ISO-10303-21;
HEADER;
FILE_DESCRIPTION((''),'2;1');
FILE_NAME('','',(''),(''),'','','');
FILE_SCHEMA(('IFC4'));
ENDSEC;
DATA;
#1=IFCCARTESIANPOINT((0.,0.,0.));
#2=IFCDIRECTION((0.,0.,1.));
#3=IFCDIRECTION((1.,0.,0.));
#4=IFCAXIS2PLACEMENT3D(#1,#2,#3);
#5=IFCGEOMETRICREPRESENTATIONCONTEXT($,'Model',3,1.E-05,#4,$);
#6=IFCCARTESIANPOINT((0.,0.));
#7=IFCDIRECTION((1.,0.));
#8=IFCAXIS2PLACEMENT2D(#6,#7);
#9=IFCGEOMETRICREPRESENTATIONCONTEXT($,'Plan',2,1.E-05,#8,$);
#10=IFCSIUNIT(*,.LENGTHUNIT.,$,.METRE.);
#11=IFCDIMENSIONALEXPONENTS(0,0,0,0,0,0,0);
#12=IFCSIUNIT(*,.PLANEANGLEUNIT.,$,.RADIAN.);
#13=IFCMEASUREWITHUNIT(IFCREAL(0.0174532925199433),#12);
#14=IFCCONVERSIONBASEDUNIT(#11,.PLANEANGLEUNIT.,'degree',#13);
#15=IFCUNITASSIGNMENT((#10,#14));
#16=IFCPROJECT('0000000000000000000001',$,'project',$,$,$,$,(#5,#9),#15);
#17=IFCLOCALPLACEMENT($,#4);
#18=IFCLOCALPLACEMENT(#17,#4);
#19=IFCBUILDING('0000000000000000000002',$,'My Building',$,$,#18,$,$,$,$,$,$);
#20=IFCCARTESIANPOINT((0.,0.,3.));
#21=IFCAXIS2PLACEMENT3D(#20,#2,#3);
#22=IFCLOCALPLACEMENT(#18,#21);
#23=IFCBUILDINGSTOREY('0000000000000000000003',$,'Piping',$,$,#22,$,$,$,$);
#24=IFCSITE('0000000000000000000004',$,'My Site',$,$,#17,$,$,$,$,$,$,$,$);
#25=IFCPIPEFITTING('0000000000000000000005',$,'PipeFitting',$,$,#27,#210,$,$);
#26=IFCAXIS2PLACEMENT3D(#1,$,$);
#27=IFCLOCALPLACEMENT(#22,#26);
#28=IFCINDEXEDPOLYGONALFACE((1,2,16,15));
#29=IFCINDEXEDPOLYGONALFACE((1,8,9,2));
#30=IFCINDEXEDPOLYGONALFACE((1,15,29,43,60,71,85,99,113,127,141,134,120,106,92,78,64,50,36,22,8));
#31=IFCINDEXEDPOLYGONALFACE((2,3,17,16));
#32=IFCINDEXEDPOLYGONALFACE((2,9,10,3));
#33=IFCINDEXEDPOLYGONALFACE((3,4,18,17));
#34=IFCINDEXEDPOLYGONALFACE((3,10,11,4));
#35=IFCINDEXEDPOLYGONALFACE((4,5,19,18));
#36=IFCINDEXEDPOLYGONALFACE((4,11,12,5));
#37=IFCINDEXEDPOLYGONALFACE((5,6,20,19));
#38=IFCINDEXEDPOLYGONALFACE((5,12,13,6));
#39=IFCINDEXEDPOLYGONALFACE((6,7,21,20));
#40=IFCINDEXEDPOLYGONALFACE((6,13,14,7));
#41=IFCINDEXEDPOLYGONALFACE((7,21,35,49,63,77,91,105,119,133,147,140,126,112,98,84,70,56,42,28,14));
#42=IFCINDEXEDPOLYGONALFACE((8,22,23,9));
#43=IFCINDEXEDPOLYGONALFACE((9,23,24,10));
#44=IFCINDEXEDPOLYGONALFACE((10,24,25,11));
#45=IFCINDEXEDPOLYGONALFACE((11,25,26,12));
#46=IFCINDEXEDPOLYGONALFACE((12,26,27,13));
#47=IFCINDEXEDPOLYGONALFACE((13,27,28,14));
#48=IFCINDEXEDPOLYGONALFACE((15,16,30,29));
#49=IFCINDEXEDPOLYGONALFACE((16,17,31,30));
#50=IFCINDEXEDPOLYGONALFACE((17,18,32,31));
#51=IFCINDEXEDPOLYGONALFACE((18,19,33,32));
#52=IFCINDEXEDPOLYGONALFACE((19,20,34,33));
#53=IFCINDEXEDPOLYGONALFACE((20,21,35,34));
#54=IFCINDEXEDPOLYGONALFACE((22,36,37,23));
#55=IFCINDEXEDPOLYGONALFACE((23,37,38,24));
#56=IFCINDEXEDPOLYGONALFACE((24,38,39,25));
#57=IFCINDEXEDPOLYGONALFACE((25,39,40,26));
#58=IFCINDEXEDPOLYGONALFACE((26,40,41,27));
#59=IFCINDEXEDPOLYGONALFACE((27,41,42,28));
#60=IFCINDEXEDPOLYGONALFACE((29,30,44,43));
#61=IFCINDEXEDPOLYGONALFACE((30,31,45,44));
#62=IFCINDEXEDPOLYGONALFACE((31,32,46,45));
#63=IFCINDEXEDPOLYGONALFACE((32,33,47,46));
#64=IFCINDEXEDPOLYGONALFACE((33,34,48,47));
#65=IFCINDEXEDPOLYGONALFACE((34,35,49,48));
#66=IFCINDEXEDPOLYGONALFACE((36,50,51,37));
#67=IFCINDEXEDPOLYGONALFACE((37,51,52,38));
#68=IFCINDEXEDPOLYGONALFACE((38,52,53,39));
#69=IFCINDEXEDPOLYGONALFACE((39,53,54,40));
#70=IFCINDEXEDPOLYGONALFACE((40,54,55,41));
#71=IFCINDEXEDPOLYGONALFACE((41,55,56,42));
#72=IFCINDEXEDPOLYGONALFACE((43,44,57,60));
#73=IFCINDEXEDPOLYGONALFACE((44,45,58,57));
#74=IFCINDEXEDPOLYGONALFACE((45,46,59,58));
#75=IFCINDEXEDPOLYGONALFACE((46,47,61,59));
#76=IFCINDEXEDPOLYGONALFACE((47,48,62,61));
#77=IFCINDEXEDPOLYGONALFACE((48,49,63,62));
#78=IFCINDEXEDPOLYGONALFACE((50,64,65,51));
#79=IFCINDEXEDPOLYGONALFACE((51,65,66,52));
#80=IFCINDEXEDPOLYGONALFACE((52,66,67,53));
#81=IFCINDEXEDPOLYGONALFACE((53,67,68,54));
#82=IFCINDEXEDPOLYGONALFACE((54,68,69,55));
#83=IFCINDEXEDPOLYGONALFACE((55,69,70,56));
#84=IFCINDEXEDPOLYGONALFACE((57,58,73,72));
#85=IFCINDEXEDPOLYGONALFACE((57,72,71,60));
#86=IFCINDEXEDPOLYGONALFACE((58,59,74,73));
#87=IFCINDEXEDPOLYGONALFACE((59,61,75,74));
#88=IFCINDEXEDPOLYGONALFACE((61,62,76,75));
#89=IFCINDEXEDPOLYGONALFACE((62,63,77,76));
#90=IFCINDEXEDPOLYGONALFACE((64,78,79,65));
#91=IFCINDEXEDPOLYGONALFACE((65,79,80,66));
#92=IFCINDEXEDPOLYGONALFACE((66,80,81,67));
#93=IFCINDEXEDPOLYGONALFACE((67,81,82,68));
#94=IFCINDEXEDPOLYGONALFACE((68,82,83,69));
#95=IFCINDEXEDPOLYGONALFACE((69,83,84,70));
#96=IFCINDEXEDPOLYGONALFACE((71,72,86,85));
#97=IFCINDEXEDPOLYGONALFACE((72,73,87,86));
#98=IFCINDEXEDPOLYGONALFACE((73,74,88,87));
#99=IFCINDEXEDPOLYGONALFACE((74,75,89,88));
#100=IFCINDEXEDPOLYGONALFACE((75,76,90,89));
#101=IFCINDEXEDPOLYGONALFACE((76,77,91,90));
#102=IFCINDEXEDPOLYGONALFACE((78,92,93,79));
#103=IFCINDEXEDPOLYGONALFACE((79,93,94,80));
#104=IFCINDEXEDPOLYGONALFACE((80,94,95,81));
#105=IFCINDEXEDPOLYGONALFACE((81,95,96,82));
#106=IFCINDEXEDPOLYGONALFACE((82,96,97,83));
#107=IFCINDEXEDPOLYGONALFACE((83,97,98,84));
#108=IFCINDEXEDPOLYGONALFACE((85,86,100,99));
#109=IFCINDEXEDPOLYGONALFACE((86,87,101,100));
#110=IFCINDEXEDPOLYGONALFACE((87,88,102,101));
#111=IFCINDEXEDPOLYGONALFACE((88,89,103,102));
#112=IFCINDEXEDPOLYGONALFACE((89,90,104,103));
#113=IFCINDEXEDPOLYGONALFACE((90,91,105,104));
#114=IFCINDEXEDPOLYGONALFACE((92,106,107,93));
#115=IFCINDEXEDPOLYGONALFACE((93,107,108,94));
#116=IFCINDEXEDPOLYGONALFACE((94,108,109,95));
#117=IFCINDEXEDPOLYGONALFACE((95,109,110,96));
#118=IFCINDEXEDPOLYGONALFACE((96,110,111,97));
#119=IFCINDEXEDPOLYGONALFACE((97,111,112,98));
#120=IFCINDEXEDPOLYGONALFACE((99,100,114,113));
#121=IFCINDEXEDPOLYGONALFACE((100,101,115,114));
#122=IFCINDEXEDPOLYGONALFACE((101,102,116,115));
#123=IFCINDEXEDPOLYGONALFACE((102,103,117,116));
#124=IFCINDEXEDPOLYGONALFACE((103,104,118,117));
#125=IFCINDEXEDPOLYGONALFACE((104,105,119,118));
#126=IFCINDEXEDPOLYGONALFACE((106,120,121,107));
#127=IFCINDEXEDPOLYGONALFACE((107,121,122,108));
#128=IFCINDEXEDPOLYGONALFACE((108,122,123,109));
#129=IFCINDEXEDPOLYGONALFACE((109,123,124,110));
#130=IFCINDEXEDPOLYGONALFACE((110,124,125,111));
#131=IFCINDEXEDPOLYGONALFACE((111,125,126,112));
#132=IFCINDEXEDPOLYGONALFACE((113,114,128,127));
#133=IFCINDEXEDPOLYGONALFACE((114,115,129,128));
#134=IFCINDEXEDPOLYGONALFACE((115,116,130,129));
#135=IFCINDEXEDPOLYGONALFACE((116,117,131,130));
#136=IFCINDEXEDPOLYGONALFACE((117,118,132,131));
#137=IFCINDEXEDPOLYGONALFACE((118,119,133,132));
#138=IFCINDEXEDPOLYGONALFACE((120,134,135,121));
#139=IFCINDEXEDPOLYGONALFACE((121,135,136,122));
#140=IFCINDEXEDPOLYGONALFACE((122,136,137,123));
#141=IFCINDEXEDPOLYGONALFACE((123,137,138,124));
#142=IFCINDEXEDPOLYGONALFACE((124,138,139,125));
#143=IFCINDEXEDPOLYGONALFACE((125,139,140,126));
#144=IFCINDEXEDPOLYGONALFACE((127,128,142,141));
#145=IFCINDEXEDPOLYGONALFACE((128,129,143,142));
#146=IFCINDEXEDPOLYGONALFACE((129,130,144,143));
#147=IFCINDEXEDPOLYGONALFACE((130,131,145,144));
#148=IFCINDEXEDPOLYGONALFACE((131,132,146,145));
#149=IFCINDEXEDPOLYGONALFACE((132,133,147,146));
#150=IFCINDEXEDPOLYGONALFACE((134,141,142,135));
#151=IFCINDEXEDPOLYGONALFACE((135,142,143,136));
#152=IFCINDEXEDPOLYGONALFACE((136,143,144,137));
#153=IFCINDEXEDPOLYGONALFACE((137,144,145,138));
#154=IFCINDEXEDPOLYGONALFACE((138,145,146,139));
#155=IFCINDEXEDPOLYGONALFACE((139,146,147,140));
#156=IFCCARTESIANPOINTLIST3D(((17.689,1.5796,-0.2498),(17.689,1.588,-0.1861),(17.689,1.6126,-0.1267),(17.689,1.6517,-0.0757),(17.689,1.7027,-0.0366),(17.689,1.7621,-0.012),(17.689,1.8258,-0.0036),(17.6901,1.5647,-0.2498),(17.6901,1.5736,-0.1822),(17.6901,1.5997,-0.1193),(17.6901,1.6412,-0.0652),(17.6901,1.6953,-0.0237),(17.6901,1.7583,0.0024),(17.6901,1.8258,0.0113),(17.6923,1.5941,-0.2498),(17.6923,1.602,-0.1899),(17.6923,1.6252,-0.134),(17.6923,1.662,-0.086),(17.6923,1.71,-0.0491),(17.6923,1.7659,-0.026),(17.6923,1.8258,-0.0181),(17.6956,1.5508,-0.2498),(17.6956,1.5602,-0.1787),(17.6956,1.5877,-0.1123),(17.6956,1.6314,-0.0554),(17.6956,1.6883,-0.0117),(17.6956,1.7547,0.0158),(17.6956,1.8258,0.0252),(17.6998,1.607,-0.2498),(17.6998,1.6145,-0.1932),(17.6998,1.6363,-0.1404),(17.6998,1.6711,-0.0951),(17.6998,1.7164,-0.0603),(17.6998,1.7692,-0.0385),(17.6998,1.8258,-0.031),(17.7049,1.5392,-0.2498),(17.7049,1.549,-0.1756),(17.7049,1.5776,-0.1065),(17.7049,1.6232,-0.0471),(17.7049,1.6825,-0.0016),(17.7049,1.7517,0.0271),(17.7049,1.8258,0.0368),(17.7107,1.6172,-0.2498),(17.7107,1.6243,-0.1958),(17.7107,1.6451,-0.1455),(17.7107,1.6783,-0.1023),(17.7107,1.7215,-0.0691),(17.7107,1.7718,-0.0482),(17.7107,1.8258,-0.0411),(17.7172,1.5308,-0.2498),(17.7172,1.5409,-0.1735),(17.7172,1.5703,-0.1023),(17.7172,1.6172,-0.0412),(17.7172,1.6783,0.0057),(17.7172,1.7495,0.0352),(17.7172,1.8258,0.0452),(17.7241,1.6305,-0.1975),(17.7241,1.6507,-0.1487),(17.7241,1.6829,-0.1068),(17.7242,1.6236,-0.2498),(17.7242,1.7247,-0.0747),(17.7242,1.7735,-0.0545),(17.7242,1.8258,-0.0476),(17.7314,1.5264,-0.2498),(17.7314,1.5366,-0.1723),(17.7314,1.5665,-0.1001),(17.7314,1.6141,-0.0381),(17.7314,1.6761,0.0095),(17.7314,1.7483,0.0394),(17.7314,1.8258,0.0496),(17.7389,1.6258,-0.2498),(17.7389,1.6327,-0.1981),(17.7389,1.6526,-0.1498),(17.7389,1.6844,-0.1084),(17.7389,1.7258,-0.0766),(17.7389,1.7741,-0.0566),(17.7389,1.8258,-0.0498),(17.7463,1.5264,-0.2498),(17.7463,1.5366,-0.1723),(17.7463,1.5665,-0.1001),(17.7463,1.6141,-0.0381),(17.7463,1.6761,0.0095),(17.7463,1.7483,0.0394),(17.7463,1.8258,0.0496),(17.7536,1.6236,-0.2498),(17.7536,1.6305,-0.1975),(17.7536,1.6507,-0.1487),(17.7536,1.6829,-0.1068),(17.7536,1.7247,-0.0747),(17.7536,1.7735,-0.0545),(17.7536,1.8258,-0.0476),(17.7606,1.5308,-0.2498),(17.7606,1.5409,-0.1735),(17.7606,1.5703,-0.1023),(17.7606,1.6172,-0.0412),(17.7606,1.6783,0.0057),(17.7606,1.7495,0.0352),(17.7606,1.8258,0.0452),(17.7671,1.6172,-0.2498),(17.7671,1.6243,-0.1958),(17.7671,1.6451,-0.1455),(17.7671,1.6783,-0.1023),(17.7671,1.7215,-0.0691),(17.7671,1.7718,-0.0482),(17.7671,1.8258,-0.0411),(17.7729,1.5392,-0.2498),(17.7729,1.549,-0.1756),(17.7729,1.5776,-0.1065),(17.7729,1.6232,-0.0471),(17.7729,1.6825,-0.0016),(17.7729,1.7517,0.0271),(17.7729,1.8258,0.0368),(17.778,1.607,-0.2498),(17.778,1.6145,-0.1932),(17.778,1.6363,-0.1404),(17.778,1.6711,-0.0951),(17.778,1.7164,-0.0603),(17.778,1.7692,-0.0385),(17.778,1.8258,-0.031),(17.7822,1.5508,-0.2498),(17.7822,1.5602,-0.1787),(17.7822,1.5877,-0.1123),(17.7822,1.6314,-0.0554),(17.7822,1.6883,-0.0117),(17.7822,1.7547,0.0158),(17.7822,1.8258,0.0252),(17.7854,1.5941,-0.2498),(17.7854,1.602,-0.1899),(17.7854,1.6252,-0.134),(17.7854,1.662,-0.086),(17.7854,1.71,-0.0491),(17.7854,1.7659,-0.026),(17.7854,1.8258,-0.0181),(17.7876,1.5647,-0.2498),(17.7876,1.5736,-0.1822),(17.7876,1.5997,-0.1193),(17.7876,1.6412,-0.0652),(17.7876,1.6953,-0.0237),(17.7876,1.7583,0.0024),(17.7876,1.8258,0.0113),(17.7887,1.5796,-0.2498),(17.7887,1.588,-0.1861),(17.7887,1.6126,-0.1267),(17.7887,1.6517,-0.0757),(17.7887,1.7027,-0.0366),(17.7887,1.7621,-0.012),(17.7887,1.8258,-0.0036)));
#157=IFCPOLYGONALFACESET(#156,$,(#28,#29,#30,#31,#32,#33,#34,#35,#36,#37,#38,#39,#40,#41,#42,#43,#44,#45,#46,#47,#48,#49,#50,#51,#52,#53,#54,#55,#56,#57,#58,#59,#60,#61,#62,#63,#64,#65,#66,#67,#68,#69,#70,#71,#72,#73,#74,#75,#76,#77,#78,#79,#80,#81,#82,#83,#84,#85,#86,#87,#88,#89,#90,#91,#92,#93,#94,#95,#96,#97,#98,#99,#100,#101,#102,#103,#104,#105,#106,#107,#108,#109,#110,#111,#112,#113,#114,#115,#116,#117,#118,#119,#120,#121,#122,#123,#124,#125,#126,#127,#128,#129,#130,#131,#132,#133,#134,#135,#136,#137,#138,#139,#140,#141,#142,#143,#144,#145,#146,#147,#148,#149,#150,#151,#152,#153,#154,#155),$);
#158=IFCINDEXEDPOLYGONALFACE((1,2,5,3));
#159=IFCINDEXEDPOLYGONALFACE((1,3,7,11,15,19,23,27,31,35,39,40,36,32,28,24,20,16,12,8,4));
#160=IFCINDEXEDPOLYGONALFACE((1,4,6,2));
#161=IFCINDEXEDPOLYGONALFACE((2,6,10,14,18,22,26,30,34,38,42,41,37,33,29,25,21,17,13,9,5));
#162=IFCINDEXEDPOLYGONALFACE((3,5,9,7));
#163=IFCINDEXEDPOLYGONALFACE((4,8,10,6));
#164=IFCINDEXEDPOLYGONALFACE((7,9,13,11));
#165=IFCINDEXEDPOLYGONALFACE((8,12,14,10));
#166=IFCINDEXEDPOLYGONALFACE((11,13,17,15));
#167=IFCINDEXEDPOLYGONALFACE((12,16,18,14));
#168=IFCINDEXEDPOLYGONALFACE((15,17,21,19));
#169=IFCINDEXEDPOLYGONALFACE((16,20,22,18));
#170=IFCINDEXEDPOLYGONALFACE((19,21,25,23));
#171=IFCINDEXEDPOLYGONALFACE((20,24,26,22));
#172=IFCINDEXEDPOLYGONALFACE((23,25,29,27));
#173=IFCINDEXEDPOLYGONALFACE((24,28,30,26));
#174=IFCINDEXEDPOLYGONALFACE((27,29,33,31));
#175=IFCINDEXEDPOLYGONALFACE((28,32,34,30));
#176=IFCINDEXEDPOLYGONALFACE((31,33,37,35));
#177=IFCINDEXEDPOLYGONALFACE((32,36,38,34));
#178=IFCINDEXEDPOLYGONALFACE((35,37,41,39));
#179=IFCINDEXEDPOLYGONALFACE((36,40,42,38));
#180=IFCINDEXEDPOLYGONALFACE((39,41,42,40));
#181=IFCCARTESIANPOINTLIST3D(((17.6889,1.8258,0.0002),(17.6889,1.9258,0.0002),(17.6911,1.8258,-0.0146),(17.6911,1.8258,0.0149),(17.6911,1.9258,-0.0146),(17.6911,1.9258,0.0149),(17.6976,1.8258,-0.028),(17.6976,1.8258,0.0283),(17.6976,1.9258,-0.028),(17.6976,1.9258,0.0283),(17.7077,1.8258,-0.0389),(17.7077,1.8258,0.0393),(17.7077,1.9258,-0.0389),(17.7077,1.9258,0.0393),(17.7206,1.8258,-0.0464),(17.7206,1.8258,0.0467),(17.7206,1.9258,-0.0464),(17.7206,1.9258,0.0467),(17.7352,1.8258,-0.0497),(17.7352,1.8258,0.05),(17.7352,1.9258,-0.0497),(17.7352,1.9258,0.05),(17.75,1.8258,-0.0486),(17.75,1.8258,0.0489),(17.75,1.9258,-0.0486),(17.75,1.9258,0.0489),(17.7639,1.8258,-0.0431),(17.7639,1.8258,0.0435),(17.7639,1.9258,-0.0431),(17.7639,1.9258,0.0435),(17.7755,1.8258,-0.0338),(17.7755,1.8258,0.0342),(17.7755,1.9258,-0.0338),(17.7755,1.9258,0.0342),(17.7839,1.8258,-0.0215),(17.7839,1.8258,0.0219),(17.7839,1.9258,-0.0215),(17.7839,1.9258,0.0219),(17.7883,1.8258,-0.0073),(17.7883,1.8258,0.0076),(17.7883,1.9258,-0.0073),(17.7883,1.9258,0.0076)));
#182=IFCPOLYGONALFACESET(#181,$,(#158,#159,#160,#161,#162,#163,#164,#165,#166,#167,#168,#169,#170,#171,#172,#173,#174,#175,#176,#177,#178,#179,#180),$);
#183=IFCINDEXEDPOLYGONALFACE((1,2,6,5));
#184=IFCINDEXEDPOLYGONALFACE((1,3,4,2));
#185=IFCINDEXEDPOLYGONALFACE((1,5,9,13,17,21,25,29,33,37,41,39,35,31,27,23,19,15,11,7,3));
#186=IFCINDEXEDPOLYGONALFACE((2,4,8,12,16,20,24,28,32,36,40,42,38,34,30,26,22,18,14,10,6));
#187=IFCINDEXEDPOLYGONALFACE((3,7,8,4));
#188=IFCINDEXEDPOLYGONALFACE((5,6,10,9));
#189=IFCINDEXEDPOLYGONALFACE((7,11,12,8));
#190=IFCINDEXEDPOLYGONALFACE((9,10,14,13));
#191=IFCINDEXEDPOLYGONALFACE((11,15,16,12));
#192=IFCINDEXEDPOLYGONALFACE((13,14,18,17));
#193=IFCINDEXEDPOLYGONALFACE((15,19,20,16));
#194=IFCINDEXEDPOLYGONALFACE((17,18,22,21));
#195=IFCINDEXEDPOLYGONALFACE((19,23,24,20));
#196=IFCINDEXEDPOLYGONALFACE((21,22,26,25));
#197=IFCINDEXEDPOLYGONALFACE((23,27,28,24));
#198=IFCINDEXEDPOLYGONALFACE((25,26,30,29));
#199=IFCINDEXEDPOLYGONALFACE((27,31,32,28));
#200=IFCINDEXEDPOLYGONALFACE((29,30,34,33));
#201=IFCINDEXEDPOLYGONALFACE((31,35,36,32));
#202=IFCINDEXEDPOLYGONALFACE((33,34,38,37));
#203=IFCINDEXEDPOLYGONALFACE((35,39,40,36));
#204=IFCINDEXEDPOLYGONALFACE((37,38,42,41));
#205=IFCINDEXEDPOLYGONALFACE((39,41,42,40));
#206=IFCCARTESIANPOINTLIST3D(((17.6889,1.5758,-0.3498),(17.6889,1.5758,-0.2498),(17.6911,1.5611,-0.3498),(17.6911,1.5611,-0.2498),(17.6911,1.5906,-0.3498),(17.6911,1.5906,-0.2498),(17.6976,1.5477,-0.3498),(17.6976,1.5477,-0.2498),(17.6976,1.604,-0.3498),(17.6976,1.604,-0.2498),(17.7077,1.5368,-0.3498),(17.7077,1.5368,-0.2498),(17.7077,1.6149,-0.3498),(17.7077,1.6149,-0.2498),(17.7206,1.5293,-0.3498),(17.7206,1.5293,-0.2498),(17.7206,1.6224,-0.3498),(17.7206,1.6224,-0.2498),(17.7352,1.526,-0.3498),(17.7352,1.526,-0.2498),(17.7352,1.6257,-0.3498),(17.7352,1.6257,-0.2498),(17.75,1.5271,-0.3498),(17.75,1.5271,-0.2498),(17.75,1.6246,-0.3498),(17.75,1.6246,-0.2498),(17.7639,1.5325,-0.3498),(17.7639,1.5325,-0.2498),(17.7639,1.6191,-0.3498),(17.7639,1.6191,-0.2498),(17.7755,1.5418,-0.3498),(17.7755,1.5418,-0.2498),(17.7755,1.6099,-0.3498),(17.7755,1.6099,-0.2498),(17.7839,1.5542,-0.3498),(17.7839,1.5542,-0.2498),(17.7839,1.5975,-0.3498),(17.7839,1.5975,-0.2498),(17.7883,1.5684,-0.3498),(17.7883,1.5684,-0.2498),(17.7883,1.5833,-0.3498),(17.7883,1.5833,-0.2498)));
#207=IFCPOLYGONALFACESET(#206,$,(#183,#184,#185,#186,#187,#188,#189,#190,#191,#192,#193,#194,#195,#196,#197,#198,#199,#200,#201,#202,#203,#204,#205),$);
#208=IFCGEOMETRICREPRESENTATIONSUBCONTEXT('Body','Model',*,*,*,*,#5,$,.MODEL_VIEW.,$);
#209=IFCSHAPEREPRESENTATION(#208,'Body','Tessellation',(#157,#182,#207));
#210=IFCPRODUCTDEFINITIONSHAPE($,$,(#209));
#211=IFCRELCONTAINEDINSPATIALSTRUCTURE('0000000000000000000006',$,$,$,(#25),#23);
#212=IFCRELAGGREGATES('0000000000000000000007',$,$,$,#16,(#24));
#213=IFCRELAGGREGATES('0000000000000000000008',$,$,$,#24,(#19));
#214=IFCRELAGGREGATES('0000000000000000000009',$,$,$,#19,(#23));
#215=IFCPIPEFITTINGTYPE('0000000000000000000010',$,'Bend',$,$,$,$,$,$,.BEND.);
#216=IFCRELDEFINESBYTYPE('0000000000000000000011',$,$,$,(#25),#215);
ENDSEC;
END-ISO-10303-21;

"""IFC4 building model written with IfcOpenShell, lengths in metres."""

from ifc_helpers import new_model, entity, si_unit, converted_unit, frame, origin_with_axes, origin_2d_with_axis, place, context, subcontext, project, spatial, circle, extrude, source, transform, mapped, type_object, type_shapes, element, save


model = new_model("IFC4")

# Units and contexts
model_context = context("Model", 3, precision=1e-05, world=origin_with_axes())
plan_context = context("Plan", 2, precision=1e-05, world=origin_2d_with_axis())
body_context = subcontext(model_context, "Body", "Model", "MODEL_VIEW")
ifc_project = project(units=[si_unit("LENGTHUNIT", "METRE"), converted_unit("PLANEANGLEUNIT", "degree", entity("IfcReal", 0.0174532925199433), si_unit("PLANEANGLEUNIT", "RADIAN"), dimensions=[0, 0, 0, 0, 0, 0, 0])], contexts=[model_context, plan_context])

# Site, building, storey
site_placement = place(None, origin_with_axes())
site = spatial("IfcSite", under=ifc_project, at=site_placement, Name="My Site")
building_placement = place(site_placement, origin_with_axes())
building = spatial("IfcBuilding", under=site, at=building_placement, Name="My Building")
storey_placement = place(building_placement, frame((0.0, 0.0, 3.0), z_axis=(0.0, 0.0, 1.0), x_axis=(1.0, 0.0, 0.0)))
storey = spatial("IfcBuildingStorey", under=building, at=storey_placement, Name="Piping")

# Pipe fitting
pipe_fitting_type = type_object("IfcPipeFittingType", Name="Bend", PredefinedType="BEND")
shared_shape = source(origin_with_axes(), body_context, "Body", "SolidModel", [
    entity("IfcSweptDiskSolid", entity("IfcIndexedPolyCurve", entity("IfcCartesianPointList3D", [[0.0, 0.0, -0.1], [0.0, -0.0732, -0.2768], [0.0, -0.25, -0.35]]), [entity("IfcArcIndex", [1, 2, 3])]), 0.05),
    extrude(circle(Radius=0.05), origin_with_axes(), (0.0, 0.0, -1.0), 0.1),
    extrude(circle(Radius=0.05), frame((0.0, -0.25, -0.35), z_axis=(0.0, -1.0, 0.0), x_axis=(1.0, 0.0, 0.0)), (0.0, 0.0, 1.0), 0.1),
])
type_shapes(pipe_fitting_type, [shared_shape])
for number, where, z_axis, x_axis, name in (
    (1, (17.7389, 1.9258, 0.0002), (0.0, 1.0, 0.0), (-1.0, 0.0, 0.0), "PipeFitting"),
):
    element("IfcPipeFitting", number, at=place(storey_placement, frame(where, z_axis=z_axis, x_axis=x_axis)), inside=storey, type_object=pipe_fitting_type, Name=name, context=body_context, shape_type="MappedRepresentation", body=[
        mapped(shared_shape, transform((0.0, 0.0, 0.0), x_axis=(1.0, 0.0, 0.0), y_axis=(0.0, 1.0, 0.0), z_axis=(0.0, 0.0, 1.0), scale=1.0)),
    ])

save(model, "model.ifc")
